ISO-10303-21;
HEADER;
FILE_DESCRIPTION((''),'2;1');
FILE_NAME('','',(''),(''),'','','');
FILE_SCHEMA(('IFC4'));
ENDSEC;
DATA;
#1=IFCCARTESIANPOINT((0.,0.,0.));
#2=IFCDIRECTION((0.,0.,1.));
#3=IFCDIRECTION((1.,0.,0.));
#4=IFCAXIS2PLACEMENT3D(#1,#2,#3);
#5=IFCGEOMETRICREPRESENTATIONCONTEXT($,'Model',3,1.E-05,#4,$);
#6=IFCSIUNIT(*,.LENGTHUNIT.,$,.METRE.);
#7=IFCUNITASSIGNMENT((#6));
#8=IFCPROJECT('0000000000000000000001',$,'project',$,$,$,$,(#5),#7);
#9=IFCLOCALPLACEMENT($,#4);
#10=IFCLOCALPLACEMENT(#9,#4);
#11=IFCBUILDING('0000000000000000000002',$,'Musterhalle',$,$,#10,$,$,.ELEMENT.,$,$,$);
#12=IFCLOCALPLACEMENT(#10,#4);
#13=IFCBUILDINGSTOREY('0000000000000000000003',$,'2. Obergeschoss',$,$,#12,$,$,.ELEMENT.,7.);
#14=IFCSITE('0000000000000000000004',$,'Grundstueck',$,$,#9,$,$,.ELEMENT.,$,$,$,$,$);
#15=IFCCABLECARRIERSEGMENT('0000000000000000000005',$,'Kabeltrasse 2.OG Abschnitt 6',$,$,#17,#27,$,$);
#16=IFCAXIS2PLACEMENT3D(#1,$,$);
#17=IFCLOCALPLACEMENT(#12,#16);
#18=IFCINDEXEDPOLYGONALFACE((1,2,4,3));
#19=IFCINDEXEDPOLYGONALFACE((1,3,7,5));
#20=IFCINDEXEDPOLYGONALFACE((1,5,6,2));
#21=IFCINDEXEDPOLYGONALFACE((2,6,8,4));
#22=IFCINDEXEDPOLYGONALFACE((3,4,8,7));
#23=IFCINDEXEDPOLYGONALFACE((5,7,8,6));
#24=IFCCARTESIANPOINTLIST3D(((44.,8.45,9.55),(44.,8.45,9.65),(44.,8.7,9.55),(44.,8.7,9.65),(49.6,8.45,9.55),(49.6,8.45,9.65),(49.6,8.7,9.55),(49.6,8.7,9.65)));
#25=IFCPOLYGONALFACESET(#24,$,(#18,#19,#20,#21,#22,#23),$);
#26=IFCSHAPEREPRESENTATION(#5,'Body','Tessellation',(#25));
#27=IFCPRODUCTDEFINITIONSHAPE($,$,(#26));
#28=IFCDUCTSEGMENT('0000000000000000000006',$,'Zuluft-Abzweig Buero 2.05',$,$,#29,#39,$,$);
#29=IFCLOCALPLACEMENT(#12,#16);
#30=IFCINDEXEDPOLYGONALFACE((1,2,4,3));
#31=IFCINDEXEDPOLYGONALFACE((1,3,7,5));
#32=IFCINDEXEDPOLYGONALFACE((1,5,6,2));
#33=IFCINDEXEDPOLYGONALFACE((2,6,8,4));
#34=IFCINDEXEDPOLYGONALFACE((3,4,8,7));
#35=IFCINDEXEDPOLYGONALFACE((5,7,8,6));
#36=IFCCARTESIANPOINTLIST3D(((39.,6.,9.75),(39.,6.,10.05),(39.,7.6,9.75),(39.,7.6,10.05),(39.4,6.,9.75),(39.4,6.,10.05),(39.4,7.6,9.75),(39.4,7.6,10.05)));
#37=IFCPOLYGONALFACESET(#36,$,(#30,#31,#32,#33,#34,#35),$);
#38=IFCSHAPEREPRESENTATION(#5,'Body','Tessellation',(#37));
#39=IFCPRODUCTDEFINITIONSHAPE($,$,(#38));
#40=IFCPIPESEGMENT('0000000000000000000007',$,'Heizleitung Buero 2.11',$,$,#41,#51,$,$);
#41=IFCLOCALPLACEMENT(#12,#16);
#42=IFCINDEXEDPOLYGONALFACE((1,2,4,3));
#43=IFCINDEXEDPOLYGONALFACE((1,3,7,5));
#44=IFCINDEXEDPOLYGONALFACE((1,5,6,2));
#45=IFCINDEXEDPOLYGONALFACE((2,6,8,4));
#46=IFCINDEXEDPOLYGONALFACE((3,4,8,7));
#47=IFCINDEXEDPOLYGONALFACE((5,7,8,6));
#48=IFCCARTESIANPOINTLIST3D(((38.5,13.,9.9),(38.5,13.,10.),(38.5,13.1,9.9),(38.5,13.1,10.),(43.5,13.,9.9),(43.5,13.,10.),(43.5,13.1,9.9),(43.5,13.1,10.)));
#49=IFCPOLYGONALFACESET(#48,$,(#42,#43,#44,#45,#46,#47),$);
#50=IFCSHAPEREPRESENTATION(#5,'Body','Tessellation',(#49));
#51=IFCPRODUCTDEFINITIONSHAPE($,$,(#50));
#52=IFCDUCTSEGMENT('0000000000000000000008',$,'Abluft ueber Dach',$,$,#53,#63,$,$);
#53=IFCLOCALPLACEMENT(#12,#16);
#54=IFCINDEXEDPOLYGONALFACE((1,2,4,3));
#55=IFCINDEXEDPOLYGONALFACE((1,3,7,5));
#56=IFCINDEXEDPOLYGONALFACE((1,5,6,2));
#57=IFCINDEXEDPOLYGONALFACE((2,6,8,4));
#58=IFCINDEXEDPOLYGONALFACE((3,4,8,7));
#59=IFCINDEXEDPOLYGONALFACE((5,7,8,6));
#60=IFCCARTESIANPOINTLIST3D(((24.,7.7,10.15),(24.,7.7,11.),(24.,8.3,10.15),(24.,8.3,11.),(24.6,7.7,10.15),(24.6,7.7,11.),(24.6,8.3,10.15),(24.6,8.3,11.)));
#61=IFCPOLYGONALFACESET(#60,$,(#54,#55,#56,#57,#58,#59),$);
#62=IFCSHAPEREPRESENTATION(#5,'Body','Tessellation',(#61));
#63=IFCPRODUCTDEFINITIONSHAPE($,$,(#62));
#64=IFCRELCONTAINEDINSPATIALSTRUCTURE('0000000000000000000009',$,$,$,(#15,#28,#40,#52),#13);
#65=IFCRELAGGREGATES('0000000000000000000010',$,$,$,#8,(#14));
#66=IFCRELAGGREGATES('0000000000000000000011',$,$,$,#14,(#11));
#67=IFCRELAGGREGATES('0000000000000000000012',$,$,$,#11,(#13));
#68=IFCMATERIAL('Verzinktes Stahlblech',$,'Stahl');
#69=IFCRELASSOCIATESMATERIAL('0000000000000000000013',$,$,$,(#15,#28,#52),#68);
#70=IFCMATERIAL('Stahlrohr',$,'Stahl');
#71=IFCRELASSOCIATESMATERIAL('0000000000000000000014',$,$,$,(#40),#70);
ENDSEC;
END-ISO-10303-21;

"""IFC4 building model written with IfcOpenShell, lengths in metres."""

from ifc_helpers import new_model, si_unit, frame, origin_with_axes, origin_2d, place, context, project, spatial, rectangle, extrude, material, element, save


model = new_model("IFC4")

# Units and contexts
model_context = context("Model", 3, precision=1e-05, world=origin_with_axes())
ifc_project = project(units=[si_unit("LENGTHUNIT", "METRE")], contexts=[model_context])

# Site, building, storey
site_placement = place(None, origin_with_axes())
site = spatial("IfcSite", under=ifc_project, at=site_placement, Name="Grundstueck", CompositionType="ELEMENT")
building_placement = place(site_placement, origin_with_axes())
building = spatial("IfcBuilding", under=site, at=building_placement, Name="Musterhalle", CompositionType="ELEMENT")
storey_placement = place(building_placement, origin_with_axes())
storey = spatial("IfcBuildingStorey", under=building, at=storey_placement, Name="2. Obergeschoss", CompositionType="ELEMENT", Elevation=7.0)

# Shared definitions
placement = place(storey_placement, origin_with_axes())

# Shared definitions
ifc_material_1 = material(Name="Stahlrohr", Category="Stahl")

# Shared definitions
ifc_material_2 = material(Name="Verzinktes Stahlblech", Category="Stahl")

# Cable carrier segment
element("IfcCableCarrierSegment", 1, at=placement, inside=storey, material=ifc_material_2, Name="Kabeltrasse 2.OG Abschnitt 6", context=model_context, shape_type="SweptSolid", body=[
    extrude(rectangle(XDim=5.6, YDim=0.25, at=origin_2d()), frame((46.8, 8.575, 9.55), z_axis=(0.0, 0.0, 1.0), x_axis=(1.0, 0.0, 0.0)), (0.0, 0.0, 1.0), 0.1),
])

# Duct segment
element("IfcDuctSegment", 2, at=placement, inside=storey, material=ifc_material_2, Name="Zuluft-Abzweig Buero 2.05", context=model_context, shape_type="SweptSolid", body=[
    extrude(rectangle(XDim=0.4, YDim=1.6, at=origin_2d()), frame((39.2, 6.8, 9.75), z_axis=(0.0, 0.0, 1.0), x_axis=(1.0, 0.0, 0.0)), (0.0, 0.0, 1.0), 0.3),
])

# Pipe segment
element("IfcPipeSegment", 3, at=placement, inside=storey, material=ifc_material_1, Name="Heizleitung Buero 2.11", context=model_context, shape_type="SweptSolid", body=[
    extrude(rectangle(XDim=5.0, YDim=0.1, at=origin_2d()), frame((41.0, 13.05, 9.9), z_axis=(0.0, 0.0, 1.0), x_axis=(1.0, 0.0, 0.0)), (0.0, 0.0, 1.0), 0.1),
])

# Duct segment
element("IfcDuctSegment", 4, at=placement, inside=storey, material=ifc_material_2, Name="Abluft ueber Dach", context=model_context, shape_type="SweptSolid", body=[
    extrude(rectangle(XDim=0.6, YDim=0.6, at=origin_2d()), frame((24.3, 8.0, 10.15), z_axis=(0.0, 0.0, 1.0), x_axis=(1.0, 0.0, 0.0)), (0.0, 0.0, 1.0), 0.85),
])

save(model, "model.ifc")
